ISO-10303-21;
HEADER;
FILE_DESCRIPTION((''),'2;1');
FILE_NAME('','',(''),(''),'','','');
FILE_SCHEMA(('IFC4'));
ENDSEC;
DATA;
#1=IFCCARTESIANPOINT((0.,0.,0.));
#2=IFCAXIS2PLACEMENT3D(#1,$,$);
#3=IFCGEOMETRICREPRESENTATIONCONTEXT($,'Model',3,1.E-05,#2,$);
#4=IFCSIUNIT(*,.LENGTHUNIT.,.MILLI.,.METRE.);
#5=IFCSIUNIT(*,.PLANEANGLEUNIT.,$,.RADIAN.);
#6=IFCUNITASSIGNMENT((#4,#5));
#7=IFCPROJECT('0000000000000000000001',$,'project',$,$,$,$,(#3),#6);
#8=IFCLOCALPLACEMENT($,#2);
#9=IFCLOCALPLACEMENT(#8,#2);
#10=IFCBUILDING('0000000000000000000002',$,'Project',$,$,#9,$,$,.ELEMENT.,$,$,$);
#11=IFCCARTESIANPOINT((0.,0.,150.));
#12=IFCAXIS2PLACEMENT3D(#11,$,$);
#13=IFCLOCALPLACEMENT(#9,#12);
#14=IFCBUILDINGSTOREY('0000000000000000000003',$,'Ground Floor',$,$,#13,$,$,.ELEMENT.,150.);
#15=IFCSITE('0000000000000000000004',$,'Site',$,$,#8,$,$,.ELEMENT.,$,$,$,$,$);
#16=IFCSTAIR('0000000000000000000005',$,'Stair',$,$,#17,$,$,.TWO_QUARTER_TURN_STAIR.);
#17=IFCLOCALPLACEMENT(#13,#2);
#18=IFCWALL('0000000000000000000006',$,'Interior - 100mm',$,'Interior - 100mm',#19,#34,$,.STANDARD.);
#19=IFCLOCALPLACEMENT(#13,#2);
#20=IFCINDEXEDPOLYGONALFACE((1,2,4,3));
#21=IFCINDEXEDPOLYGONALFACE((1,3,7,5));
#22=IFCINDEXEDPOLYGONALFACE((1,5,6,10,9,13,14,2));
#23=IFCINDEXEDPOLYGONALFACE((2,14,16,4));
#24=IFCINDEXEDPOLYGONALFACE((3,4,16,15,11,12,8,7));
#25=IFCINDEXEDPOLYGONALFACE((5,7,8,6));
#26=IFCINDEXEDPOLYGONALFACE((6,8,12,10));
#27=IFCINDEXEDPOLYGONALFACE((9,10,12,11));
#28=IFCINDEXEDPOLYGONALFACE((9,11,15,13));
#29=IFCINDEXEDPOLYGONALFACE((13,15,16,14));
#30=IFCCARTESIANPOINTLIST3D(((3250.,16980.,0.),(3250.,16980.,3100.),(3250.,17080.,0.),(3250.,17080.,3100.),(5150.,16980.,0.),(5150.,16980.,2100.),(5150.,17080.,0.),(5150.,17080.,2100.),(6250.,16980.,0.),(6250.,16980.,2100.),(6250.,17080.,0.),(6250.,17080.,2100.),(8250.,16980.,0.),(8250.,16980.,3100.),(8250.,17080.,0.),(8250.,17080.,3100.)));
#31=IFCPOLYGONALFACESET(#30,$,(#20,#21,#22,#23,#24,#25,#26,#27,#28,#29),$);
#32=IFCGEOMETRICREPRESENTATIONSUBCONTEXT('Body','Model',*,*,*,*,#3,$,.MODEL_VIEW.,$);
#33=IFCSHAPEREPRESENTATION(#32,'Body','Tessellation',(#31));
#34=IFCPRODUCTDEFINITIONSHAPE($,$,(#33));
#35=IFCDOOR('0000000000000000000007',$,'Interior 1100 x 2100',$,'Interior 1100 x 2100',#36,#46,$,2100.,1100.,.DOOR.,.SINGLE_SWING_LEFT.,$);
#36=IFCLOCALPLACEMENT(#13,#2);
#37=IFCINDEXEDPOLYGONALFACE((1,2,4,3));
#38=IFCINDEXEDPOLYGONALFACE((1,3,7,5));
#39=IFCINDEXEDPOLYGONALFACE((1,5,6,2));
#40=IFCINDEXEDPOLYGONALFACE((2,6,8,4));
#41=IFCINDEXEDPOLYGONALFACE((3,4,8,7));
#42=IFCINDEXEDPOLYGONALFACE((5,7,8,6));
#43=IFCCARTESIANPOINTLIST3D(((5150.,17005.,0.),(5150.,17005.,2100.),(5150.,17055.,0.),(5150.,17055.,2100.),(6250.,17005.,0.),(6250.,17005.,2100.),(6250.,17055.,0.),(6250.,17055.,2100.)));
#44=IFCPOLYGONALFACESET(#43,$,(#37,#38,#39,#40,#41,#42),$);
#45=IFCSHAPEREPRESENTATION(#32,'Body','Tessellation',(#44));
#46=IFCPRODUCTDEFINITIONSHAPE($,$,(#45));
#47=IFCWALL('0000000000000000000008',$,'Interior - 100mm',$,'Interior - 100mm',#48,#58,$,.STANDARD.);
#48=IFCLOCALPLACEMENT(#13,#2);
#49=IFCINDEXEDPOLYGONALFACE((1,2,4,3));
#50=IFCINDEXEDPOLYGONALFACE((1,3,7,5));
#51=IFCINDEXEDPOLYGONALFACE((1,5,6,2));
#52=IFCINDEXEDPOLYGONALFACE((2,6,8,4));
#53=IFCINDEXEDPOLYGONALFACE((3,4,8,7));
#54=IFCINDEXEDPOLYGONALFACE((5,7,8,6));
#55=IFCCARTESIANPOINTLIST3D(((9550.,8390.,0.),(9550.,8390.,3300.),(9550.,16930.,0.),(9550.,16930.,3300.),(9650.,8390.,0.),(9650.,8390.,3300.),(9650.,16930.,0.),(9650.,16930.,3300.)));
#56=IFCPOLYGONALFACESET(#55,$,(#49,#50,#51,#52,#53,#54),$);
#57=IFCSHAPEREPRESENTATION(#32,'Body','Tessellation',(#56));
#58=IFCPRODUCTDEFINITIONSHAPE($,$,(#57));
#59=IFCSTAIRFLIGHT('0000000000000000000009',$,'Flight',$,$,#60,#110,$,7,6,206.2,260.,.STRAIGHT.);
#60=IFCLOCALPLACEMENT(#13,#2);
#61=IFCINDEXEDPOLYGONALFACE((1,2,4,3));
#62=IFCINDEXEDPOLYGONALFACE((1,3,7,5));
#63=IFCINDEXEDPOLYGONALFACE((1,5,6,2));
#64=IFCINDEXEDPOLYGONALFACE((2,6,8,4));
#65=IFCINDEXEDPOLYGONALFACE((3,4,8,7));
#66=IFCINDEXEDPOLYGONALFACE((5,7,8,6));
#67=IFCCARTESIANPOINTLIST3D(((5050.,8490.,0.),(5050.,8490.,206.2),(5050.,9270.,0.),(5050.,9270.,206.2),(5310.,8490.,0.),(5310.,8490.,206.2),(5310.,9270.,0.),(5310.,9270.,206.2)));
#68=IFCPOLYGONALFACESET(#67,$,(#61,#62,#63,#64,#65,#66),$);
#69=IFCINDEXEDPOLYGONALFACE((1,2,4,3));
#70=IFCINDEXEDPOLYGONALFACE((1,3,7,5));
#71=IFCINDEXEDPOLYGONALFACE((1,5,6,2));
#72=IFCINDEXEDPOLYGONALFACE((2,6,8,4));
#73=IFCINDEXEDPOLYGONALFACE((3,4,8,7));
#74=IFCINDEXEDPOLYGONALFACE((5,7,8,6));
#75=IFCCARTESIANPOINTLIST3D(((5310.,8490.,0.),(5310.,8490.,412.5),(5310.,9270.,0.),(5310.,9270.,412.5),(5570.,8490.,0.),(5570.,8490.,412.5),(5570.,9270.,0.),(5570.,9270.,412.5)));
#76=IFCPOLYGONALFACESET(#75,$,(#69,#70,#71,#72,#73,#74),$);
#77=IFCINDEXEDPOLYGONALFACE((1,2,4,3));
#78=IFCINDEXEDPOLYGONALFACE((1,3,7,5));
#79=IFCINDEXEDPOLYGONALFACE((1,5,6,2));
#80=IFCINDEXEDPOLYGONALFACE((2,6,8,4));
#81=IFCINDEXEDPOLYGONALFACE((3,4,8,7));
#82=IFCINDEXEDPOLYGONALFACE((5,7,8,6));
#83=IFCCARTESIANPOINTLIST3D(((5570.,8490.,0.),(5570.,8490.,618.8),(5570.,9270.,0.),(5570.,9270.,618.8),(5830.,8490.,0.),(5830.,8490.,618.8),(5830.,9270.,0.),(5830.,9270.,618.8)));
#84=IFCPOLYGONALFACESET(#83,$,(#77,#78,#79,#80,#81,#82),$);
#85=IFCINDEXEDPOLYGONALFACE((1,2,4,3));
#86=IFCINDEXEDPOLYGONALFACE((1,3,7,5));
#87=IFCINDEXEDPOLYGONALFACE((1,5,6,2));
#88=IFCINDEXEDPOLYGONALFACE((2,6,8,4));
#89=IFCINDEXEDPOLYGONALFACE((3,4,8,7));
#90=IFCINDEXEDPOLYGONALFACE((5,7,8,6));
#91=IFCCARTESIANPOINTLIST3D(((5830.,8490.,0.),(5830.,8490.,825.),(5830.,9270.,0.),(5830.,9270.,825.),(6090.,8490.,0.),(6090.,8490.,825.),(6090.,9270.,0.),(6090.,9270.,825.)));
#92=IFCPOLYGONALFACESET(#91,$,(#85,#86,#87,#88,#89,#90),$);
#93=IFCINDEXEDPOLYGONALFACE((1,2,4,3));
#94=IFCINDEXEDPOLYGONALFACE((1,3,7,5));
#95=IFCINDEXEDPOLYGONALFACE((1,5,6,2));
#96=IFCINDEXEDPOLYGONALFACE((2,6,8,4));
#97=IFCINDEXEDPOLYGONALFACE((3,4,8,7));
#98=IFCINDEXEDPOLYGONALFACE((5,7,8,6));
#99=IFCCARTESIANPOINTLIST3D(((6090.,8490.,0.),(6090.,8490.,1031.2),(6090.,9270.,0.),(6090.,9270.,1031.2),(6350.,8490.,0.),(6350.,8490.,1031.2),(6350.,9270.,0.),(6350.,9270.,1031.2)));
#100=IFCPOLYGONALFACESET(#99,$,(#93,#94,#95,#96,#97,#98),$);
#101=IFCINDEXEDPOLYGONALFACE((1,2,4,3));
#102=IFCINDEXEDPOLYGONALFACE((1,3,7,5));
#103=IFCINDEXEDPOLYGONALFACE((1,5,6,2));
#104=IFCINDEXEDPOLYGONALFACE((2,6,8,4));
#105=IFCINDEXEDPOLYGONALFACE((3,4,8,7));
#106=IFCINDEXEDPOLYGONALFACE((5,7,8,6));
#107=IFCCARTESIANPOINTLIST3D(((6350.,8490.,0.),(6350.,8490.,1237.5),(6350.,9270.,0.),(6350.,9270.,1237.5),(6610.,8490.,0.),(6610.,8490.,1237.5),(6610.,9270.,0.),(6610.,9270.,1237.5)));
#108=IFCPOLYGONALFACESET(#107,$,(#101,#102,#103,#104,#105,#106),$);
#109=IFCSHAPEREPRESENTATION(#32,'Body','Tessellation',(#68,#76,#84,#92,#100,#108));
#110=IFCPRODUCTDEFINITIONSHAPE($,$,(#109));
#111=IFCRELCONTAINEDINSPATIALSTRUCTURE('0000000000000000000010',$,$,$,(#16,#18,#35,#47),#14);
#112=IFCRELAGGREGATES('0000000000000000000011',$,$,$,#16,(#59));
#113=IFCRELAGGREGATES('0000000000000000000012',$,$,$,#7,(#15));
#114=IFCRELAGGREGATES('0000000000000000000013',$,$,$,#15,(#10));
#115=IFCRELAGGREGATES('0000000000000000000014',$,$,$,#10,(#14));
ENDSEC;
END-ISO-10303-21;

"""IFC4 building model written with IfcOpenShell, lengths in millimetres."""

from ifc_helpers import new_model, si_unit, frame, frame_2d, origin, place, context, subcontext, project, spatial, polyline, rectangle, outline, extrude, element, fill, aggregate, save


model = new_model("IFC4")

# Units and contexts
model_context = context("Model", 3, precision=1e-05, world=origin())
body_context = subcontext(model_context, "Body", "Model", "MODEL_VIEW")
ifc_project = project(units=[si_unit("LENGTHUNIT", "METRE", prefix="MILLI"), si_unit("PLANEANGLEUNIT", "RADIAN")], contexts=[model_context])

# Site, building, storey
site_placement = place(None, origin())
site = spatial("IfcSite", under=ifc_project, at=site_placement, Name="Site", CompositionType="ELEMENT")
building_placement = place(site_placement, origin())
building = spatial("IfcBuilding", under=site, at=building_placement, Name="Project", CompositionType="ELEMENT")
storey_placement = place(building_placement, frame((0.0, 0.0, 150.0)))
storey = spatial("IfcBuildingStorey", under=building, at=storey_placement, Name="Ground Floor", CompositionType="ELEMENT", Elevation=150.0)

# Stair
stair_placement = place(storey_placement, origin())
stair = element("IfcStair", 1, at=stair_placement, inside=storey, Name="Stair", PredefinedType="TWO_QUARTER_TURN_STAIR")

# Wall, opening, door
wall_1_placement = place(storey_placement, frame((3150.0, 17030.0, 0.0), z_axis=(0.0, 0.0, 1.0), x_axis=(1.0, 0.0, 0.0)))
wall_1 = element("IfcWall", 2, at=wall_1_placement, inside=storey, Name="Interior - 100mm", ObjectType="Interior - 100mm", PredefinedType="STANDARD", context=body_context, shape_type="SweptSolid", body=[
    extrude(outline(polyline([(100.0, -50.0), (100.0, 50.0), (5100.0, 50.0), (5100.0, -50.0), (100.0, -50.0)])), origin(), (0.0, 0.0, 1.0), 3100.0),
])
opening_1_placement = place(wall_1_placement, frame((2000.0, 0.0, 0.0), z_axis=(0.0, 0.0, 1.0), x_axis=(1.0, 0.0, 0.0)))
opening_1 = element("IfcOpeningElement", 3, at=opening_1_placement, cuts=wall_1, PredefinedType="OPENING", context=body_context, shape_type="SweptSolid", body=[
    extrude(rectangle(XDim=1100.0, YDim=120.0, at=frame_2d((550.0, 0.0))), origin(), (0.0, 0.0, 1.0), 2100.0),
])
door_1_placement = place(opening_1_placement, origin())
door_1 = element("IfcDoor", 4, at=door_1_placement, inside=storey, Name="Interior 1100 x 2100", ObjectType="Interior 1100 x 2100", OperationType="SINGLE_SWING_LEFT", OverallHeight=2100.0, OverallWidth=1100.0, PredefinedType="DOOR", context=body_context, shape_type="SweptSolid", body=[
    extrude(rectangle(XDim=1100.0, YDim=50.0, at=frame_2d((550.0, 0.0))), origin(), (0.0, 0.0, 1.0), 2100.0),
])
fill(opening_1, door_1)

# Wall
wall_2_placement = place(storey_placement, frame((9600.0, 8390.0, 0.0), z_axis=(0.0, 0.0, 1.0), x_axis=(0.0, 1.0, 0.0)))
element("IfcWall", 5, at=wall_2_placement, inside=storey, Name="Interior - 100mm", ObjectType="Interior - 100mm", PredefinedType="STANDARD", context=body_context, shape_type="SweptSolid", body=[
    extrude(outline(polyline([(0.0, -50.0), (0.0, 50.0), (8540.0, 50.0), (8540.0, -50.0), (0.0, -50.0)])), origin(), (0.0, 0.0, 1.0), 3300.0),
])

# Stair flight
stair_flight_1_placement = place(stair_placement, frame((5050.0, 8880.0, 0.0), z_axis=(0.0, 0.0, 1.0), x_axis=(1.0, 0.0, 0.0)))
stair_flight_1 = element("IfcStairFlight", 6, at=stair_flight_1_placement, Name="Flight", NumberOfRisers=7, NumberOfTreads=6, PredefinedType="STRAIGHT", RiserHeight=206.2, TreadLength=260.0, context=body_context, shape_type="SweptSolid", body=[
    extrude(rectangle(XDim=260.0, YDim=780.0, at=frame_2d((130.0, 0.0))), origin(), (0.0, 0.0, 1.0), 206.2),
    extrude(rectangle(XDim=260.0, YDim=780.0, at=frame_2d((390.0, 0.0))), origin(), (0.0, 0.0, 1.0), 412.5),
    extrude(rectangle(XDim=260.0, YDim=780.0, at=frame_2d((650.0, 0.0))), origin(), (0.0, 0.0, 1.0), 618.8),
    extrude(rectangle(XDim=260.0, YDim=780.0, at=frame_2d((910.0, 0.0))), origin(), (0.0, 0.0, 1.0), 825.0),
    extrude(rectangle(XDim=260.0, YDim=780.0, at=frame_2d((1170.0, 0.0))), origin(), (0.0, 0.0, 1.0), 1031.2),
    extrude(rectangle(XDim=260.0, YDim=780.0, at=frame_2d((1430.0, 0.0))), origin(), (0.0, 0.0, 1.0), 1237.5),
])
aggregate(stair, [stair_flight_1])

save(model, "model.ifc")
